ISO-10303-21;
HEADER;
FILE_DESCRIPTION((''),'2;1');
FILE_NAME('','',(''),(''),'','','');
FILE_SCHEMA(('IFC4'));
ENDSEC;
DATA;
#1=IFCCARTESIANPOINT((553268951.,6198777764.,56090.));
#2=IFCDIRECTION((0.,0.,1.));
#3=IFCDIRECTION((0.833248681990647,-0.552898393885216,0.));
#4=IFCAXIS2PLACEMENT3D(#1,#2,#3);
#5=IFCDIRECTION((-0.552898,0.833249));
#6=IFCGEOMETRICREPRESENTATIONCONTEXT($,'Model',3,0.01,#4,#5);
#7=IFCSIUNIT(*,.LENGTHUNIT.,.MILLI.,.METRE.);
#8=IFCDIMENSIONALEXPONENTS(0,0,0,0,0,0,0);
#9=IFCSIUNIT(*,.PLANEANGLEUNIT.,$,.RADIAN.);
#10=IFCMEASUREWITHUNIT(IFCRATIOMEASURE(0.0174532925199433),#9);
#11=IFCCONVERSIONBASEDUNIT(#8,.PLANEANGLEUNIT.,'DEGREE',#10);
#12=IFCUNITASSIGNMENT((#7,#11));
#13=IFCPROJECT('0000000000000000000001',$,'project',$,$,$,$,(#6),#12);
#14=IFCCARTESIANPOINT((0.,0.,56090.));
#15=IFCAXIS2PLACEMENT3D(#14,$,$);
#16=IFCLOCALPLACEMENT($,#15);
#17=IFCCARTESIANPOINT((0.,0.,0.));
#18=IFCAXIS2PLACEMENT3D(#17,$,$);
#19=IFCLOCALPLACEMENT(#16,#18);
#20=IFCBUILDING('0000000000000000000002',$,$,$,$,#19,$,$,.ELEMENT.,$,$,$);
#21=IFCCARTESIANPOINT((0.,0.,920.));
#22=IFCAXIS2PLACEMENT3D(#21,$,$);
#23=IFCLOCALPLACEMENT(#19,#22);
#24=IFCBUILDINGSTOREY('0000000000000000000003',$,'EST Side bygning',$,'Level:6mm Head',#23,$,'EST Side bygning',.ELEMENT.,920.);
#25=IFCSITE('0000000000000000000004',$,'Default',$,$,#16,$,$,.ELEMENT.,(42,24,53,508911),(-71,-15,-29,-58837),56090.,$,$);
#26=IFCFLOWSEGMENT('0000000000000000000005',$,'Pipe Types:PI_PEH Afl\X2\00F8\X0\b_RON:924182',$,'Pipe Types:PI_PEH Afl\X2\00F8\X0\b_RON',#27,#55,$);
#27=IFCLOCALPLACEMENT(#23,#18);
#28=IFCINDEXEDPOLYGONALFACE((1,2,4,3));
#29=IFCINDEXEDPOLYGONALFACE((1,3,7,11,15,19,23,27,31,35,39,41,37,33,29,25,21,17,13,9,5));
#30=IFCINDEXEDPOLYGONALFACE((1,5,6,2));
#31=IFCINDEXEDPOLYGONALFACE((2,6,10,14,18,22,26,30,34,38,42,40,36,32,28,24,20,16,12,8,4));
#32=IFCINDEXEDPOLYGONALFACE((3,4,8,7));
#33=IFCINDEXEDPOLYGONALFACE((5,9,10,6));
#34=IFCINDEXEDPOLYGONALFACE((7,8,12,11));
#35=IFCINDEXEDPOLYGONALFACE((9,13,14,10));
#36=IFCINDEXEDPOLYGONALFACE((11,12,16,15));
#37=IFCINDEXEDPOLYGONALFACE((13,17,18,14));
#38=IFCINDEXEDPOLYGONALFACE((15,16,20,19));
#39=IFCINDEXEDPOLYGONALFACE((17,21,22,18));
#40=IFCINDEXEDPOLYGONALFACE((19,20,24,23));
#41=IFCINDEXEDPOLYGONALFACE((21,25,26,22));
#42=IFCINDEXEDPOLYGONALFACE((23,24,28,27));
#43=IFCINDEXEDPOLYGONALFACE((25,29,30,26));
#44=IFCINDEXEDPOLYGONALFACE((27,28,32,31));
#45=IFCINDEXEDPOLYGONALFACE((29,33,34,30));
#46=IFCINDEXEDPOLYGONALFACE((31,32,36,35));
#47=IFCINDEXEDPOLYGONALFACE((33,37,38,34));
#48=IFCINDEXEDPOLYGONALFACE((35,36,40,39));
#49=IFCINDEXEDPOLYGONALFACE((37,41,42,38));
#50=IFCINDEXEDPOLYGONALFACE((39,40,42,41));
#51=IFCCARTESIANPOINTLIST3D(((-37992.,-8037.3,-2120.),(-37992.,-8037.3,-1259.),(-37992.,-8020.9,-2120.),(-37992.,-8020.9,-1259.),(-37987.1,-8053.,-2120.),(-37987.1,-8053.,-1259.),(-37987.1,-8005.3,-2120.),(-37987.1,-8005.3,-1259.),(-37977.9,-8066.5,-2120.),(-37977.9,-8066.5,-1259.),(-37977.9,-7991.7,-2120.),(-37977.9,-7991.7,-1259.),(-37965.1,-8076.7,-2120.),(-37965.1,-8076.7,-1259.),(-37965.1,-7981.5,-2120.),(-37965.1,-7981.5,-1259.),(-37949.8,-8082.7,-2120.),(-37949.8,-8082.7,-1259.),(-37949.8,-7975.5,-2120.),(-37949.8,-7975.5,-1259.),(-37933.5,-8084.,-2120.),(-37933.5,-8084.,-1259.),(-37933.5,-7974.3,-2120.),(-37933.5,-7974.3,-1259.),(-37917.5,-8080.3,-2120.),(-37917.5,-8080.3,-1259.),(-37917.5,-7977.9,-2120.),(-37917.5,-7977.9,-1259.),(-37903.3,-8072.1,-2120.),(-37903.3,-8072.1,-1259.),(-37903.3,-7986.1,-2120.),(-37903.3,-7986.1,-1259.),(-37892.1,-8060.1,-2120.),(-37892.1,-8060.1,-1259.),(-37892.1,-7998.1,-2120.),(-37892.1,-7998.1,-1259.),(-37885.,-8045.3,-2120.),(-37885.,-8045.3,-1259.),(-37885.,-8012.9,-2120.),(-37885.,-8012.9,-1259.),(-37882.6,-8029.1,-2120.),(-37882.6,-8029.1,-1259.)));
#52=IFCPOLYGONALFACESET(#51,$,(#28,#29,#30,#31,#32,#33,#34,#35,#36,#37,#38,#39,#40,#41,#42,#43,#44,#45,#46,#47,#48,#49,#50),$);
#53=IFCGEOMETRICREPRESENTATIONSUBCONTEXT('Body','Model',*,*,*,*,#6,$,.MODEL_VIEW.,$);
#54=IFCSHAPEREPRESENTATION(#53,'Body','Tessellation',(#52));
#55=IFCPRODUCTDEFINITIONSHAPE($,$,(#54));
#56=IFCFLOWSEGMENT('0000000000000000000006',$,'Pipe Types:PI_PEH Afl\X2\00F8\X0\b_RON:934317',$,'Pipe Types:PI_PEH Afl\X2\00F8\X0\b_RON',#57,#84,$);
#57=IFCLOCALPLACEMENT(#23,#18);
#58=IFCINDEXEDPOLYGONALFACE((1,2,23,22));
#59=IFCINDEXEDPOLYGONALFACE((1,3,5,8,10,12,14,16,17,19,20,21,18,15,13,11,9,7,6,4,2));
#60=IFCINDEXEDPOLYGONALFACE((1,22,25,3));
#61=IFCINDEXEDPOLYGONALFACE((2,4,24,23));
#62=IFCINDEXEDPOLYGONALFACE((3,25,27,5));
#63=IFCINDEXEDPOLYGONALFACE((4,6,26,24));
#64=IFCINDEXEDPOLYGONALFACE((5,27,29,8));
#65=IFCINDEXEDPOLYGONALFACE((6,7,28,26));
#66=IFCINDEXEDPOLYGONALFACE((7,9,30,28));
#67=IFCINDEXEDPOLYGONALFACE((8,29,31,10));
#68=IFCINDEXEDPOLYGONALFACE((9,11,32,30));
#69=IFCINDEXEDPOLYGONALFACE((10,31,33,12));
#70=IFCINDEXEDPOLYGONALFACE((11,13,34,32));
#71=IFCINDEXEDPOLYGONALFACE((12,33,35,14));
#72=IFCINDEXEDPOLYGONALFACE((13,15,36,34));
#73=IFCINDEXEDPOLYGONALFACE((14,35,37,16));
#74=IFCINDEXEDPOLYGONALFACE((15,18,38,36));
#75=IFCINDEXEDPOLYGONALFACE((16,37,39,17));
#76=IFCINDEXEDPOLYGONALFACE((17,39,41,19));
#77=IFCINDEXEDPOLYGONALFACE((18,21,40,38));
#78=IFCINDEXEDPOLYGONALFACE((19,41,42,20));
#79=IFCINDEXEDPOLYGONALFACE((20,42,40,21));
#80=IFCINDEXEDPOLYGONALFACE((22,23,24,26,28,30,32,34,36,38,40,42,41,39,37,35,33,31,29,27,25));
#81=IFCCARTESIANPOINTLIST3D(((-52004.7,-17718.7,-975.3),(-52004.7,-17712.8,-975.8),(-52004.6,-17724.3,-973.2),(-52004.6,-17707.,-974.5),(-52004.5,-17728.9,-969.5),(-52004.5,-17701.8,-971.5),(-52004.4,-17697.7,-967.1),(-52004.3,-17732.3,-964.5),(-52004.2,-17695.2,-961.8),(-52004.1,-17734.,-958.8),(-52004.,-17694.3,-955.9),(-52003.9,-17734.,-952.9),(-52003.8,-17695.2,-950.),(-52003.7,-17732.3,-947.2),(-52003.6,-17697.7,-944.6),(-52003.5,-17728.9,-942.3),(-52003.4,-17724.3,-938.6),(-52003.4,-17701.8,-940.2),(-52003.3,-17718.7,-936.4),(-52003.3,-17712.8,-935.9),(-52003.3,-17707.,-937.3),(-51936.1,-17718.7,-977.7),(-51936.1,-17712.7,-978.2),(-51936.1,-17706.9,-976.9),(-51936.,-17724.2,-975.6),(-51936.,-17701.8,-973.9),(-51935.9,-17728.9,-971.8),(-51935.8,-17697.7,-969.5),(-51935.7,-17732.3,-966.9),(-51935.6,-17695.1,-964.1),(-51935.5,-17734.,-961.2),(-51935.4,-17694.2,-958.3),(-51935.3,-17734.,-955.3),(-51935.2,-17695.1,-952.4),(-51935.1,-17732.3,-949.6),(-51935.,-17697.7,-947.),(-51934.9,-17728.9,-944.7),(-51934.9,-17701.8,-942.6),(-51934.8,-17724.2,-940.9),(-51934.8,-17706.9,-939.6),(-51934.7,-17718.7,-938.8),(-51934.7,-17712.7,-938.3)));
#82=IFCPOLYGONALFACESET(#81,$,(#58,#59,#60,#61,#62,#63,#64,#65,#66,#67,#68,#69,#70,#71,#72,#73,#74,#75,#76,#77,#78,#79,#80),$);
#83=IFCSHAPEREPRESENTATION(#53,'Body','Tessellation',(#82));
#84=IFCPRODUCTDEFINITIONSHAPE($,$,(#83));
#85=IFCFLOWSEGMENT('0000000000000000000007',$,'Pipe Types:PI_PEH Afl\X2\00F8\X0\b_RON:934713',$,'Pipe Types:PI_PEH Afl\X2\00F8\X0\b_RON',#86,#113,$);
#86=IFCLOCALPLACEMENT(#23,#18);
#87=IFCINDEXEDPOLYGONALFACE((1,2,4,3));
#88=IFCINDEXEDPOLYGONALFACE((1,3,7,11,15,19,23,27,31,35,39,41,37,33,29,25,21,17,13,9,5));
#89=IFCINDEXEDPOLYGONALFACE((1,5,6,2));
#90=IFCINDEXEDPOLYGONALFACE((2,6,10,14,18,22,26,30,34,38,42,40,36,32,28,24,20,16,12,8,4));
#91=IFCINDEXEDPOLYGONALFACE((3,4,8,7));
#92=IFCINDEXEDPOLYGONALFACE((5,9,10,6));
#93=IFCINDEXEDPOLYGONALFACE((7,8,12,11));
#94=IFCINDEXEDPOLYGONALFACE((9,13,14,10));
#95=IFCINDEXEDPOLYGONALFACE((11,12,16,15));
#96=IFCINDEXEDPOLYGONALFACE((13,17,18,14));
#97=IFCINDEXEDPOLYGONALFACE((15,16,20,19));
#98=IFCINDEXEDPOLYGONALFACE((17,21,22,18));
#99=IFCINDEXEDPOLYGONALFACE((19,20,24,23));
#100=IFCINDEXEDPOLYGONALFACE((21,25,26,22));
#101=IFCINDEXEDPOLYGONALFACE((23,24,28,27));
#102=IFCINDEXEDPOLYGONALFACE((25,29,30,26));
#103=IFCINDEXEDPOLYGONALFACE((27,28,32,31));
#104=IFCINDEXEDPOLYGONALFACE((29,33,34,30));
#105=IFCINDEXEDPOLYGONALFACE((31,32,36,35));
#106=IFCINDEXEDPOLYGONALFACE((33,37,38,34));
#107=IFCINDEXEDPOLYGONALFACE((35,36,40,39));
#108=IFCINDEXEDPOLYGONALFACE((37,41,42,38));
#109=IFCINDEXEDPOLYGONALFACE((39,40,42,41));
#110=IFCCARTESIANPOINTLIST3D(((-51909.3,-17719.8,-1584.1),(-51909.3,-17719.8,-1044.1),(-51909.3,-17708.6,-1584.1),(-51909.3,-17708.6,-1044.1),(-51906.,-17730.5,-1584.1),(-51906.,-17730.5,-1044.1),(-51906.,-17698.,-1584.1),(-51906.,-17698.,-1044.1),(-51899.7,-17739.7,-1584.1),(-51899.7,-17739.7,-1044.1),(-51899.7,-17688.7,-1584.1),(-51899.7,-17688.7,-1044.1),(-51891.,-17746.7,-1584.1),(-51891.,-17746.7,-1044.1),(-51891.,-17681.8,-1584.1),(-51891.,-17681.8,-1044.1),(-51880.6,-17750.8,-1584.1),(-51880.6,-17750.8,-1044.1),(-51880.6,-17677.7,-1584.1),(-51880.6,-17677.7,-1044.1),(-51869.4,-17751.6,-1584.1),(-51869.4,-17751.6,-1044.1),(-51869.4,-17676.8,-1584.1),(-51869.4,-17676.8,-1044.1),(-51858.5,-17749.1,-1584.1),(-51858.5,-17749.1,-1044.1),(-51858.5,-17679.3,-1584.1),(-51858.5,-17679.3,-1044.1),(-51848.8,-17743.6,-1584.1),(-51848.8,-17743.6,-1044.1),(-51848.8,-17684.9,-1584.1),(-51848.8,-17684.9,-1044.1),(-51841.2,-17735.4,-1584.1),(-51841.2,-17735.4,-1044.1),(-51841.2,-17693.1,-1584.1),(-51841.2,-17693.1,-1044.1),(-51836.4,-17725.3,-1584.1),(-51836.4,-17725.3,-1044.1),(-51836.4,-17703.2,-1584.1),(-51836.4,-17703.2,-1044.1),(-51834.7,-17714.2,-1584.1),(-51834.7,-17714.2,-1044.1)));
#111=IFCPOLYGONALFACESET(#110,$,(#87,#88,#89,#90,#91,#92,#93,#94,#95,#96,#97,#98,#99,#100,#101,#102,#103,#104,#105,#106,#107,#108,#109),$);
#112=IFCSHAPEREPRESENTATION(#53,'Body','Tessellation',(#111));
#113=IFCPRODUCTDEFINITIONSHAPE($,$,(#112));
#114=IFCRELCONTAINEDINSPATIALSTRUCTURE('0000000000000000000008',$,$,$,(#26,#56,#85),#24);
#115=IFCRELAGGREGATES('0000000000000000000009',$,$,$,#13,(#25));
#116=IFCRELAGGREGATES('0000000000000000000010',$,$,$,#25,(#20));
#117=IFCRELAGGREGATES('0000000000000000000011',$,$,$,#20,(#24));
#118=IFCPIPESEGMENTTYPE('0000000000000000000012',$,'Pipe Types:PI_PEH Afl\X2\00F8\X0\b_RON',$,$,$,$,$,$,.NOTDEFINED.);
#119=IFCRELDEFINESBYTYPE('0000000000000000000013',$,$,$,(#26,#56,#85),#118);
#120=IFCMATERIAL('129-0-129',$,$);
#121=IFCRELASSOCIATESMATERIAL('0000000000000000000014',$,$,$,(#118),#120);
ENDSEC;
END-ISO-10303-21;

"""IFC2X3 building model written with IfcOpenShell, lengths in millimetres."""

from ifc_helpers import new_model, entity, si_unit, converted_unit, direction, frame, frame_2d, origin, origin_2d_with_axis, place, context, subcontext, project, spatial, circle, extrude, material, type_object, element, save


model = new_model("IFC2X3")

# Units and contexts
model_context = context("Model", 3, precision=0.01, world=frame((553268951.0, 6198777764.0, 56090.0), z_axis=(0.0, 0.0, 1.0), x_axis=(0.833248681990647, -0.552898393885216, 0.0)), true_north=direction((-0.552898, 0.833249)))
body_context = subcontext(model_context, "Body", "Model", "MODEL_VIEW")
ifc_project = project(units=[si_unit("LENGTHUNIT", "METRE", prefix="MILLI"), converted_unit("PLANEANGLEUNIT", "DEGREE", entity("IfcRatioMeasure", 0.0174532925199433), si_unit("PLANEANGLEUNIT", "RADIAN"), dimensions=[0, 0, 0, 0, 0, 0, 0])], contexts=[model_context])

# Site, building, storey
site_placement = place(None, frame((0.0, 0.0, 56090.0)))
site = spatial("IfcSite", under=ifc_project, at=site_placement, Name="Default", CompositionType="ELEMENT", RefLatitude=(42, 24, 53, 508911), RefLongitude=(-71, -15, -29, -58837), RefElevation=56090.0)
building_placement = place(site_placement, origin())
building = spatial("IfcBuilding", under=site, at=building_placement, CompositionType="ELEMENT")
storey_placement = place(building_placement, frame((0.0, 0.0, 920.0)))
storey = spatial("IfcBuildingStorey", under=building, at=storey_placement, Name="EST Side bygning", ObjectType="Level:6mm Head", LongName="EST Side bygning", CompositionType="ELEMENT", Elevation=920.0)

# Flow segments
ifc_material_1 = material(Name="129-0-129")
pipe_segment_type_1 = type_object("IfcPipeSegmentType", Name="Pipe Types:PI_PEH Afløb_RON", PredefinedType="NOTDEFINED", material=ifc_material_1)
flow_segment_1_placement = place(storey_placement, origin())
element("IfcFlowSegment", 1, at=flow_segment_1_placement, inside=storey, type_object=pipe_segment_type_1, Name="Pipe Types:PI_PEH Afløb_RON:924182", ObjectType="Pipe Types:PI_PEH Afløb_RON", context=body_context, shape_type="SweptSolid", body=[
    extrude(circle(Radius=55.0, at=origin_2d_with_axis()), frame((-37937.6, -8029.1, -2120.0)), (0.0, 0.0, 1.0), 861.0),
])
flow_segment_2_placement = place(storey_placement, origin())
element("IfcFlowSegment", 2, at=flow_segment_2_placement, inside=storey, type_object=pipe_segment_type_1, Name="Pipe Types:PI_PEH Afløb_RON:934317", ObjectType="Pipe Types:PI_PEH Afløb_RON", context=body_context, shape_type="SweptSolid", body=[
    extrude(circle(Radius=20.0, at=frame_2d((0.0, 0.0), x_axis=(1.0, 0.0))), frame((-51935.4, -17714.2, -958.3), z_axis=(-0.999391, -0.000368, 0.034899), x_axis=(-0.000369, 1.0, 0.0)), (0.0, 0.0, 1.0), 68.6),
])
flow_segment_3_placement = place(storey_placement, origin())
element("IfcFlowSegment", 3, at=flow_segment_3_placement, inside=storey, type_object=pipe_segment_type_1, Name="Pipe Types:PI_PEH Afløb_RON:934713", ObjectType="Pipe Types:PI_PEH Afløb_RON", context=body_context, shape_type="SweptSolid", body=[
    extrude(circle(Radius=37.5, at=origin_2d_with_axis()), frame((-51872.2, -17714.2, -1584.1)), (0.0, 0.0, 1.0), 540.0),
])

save(model, "model.ifc")
